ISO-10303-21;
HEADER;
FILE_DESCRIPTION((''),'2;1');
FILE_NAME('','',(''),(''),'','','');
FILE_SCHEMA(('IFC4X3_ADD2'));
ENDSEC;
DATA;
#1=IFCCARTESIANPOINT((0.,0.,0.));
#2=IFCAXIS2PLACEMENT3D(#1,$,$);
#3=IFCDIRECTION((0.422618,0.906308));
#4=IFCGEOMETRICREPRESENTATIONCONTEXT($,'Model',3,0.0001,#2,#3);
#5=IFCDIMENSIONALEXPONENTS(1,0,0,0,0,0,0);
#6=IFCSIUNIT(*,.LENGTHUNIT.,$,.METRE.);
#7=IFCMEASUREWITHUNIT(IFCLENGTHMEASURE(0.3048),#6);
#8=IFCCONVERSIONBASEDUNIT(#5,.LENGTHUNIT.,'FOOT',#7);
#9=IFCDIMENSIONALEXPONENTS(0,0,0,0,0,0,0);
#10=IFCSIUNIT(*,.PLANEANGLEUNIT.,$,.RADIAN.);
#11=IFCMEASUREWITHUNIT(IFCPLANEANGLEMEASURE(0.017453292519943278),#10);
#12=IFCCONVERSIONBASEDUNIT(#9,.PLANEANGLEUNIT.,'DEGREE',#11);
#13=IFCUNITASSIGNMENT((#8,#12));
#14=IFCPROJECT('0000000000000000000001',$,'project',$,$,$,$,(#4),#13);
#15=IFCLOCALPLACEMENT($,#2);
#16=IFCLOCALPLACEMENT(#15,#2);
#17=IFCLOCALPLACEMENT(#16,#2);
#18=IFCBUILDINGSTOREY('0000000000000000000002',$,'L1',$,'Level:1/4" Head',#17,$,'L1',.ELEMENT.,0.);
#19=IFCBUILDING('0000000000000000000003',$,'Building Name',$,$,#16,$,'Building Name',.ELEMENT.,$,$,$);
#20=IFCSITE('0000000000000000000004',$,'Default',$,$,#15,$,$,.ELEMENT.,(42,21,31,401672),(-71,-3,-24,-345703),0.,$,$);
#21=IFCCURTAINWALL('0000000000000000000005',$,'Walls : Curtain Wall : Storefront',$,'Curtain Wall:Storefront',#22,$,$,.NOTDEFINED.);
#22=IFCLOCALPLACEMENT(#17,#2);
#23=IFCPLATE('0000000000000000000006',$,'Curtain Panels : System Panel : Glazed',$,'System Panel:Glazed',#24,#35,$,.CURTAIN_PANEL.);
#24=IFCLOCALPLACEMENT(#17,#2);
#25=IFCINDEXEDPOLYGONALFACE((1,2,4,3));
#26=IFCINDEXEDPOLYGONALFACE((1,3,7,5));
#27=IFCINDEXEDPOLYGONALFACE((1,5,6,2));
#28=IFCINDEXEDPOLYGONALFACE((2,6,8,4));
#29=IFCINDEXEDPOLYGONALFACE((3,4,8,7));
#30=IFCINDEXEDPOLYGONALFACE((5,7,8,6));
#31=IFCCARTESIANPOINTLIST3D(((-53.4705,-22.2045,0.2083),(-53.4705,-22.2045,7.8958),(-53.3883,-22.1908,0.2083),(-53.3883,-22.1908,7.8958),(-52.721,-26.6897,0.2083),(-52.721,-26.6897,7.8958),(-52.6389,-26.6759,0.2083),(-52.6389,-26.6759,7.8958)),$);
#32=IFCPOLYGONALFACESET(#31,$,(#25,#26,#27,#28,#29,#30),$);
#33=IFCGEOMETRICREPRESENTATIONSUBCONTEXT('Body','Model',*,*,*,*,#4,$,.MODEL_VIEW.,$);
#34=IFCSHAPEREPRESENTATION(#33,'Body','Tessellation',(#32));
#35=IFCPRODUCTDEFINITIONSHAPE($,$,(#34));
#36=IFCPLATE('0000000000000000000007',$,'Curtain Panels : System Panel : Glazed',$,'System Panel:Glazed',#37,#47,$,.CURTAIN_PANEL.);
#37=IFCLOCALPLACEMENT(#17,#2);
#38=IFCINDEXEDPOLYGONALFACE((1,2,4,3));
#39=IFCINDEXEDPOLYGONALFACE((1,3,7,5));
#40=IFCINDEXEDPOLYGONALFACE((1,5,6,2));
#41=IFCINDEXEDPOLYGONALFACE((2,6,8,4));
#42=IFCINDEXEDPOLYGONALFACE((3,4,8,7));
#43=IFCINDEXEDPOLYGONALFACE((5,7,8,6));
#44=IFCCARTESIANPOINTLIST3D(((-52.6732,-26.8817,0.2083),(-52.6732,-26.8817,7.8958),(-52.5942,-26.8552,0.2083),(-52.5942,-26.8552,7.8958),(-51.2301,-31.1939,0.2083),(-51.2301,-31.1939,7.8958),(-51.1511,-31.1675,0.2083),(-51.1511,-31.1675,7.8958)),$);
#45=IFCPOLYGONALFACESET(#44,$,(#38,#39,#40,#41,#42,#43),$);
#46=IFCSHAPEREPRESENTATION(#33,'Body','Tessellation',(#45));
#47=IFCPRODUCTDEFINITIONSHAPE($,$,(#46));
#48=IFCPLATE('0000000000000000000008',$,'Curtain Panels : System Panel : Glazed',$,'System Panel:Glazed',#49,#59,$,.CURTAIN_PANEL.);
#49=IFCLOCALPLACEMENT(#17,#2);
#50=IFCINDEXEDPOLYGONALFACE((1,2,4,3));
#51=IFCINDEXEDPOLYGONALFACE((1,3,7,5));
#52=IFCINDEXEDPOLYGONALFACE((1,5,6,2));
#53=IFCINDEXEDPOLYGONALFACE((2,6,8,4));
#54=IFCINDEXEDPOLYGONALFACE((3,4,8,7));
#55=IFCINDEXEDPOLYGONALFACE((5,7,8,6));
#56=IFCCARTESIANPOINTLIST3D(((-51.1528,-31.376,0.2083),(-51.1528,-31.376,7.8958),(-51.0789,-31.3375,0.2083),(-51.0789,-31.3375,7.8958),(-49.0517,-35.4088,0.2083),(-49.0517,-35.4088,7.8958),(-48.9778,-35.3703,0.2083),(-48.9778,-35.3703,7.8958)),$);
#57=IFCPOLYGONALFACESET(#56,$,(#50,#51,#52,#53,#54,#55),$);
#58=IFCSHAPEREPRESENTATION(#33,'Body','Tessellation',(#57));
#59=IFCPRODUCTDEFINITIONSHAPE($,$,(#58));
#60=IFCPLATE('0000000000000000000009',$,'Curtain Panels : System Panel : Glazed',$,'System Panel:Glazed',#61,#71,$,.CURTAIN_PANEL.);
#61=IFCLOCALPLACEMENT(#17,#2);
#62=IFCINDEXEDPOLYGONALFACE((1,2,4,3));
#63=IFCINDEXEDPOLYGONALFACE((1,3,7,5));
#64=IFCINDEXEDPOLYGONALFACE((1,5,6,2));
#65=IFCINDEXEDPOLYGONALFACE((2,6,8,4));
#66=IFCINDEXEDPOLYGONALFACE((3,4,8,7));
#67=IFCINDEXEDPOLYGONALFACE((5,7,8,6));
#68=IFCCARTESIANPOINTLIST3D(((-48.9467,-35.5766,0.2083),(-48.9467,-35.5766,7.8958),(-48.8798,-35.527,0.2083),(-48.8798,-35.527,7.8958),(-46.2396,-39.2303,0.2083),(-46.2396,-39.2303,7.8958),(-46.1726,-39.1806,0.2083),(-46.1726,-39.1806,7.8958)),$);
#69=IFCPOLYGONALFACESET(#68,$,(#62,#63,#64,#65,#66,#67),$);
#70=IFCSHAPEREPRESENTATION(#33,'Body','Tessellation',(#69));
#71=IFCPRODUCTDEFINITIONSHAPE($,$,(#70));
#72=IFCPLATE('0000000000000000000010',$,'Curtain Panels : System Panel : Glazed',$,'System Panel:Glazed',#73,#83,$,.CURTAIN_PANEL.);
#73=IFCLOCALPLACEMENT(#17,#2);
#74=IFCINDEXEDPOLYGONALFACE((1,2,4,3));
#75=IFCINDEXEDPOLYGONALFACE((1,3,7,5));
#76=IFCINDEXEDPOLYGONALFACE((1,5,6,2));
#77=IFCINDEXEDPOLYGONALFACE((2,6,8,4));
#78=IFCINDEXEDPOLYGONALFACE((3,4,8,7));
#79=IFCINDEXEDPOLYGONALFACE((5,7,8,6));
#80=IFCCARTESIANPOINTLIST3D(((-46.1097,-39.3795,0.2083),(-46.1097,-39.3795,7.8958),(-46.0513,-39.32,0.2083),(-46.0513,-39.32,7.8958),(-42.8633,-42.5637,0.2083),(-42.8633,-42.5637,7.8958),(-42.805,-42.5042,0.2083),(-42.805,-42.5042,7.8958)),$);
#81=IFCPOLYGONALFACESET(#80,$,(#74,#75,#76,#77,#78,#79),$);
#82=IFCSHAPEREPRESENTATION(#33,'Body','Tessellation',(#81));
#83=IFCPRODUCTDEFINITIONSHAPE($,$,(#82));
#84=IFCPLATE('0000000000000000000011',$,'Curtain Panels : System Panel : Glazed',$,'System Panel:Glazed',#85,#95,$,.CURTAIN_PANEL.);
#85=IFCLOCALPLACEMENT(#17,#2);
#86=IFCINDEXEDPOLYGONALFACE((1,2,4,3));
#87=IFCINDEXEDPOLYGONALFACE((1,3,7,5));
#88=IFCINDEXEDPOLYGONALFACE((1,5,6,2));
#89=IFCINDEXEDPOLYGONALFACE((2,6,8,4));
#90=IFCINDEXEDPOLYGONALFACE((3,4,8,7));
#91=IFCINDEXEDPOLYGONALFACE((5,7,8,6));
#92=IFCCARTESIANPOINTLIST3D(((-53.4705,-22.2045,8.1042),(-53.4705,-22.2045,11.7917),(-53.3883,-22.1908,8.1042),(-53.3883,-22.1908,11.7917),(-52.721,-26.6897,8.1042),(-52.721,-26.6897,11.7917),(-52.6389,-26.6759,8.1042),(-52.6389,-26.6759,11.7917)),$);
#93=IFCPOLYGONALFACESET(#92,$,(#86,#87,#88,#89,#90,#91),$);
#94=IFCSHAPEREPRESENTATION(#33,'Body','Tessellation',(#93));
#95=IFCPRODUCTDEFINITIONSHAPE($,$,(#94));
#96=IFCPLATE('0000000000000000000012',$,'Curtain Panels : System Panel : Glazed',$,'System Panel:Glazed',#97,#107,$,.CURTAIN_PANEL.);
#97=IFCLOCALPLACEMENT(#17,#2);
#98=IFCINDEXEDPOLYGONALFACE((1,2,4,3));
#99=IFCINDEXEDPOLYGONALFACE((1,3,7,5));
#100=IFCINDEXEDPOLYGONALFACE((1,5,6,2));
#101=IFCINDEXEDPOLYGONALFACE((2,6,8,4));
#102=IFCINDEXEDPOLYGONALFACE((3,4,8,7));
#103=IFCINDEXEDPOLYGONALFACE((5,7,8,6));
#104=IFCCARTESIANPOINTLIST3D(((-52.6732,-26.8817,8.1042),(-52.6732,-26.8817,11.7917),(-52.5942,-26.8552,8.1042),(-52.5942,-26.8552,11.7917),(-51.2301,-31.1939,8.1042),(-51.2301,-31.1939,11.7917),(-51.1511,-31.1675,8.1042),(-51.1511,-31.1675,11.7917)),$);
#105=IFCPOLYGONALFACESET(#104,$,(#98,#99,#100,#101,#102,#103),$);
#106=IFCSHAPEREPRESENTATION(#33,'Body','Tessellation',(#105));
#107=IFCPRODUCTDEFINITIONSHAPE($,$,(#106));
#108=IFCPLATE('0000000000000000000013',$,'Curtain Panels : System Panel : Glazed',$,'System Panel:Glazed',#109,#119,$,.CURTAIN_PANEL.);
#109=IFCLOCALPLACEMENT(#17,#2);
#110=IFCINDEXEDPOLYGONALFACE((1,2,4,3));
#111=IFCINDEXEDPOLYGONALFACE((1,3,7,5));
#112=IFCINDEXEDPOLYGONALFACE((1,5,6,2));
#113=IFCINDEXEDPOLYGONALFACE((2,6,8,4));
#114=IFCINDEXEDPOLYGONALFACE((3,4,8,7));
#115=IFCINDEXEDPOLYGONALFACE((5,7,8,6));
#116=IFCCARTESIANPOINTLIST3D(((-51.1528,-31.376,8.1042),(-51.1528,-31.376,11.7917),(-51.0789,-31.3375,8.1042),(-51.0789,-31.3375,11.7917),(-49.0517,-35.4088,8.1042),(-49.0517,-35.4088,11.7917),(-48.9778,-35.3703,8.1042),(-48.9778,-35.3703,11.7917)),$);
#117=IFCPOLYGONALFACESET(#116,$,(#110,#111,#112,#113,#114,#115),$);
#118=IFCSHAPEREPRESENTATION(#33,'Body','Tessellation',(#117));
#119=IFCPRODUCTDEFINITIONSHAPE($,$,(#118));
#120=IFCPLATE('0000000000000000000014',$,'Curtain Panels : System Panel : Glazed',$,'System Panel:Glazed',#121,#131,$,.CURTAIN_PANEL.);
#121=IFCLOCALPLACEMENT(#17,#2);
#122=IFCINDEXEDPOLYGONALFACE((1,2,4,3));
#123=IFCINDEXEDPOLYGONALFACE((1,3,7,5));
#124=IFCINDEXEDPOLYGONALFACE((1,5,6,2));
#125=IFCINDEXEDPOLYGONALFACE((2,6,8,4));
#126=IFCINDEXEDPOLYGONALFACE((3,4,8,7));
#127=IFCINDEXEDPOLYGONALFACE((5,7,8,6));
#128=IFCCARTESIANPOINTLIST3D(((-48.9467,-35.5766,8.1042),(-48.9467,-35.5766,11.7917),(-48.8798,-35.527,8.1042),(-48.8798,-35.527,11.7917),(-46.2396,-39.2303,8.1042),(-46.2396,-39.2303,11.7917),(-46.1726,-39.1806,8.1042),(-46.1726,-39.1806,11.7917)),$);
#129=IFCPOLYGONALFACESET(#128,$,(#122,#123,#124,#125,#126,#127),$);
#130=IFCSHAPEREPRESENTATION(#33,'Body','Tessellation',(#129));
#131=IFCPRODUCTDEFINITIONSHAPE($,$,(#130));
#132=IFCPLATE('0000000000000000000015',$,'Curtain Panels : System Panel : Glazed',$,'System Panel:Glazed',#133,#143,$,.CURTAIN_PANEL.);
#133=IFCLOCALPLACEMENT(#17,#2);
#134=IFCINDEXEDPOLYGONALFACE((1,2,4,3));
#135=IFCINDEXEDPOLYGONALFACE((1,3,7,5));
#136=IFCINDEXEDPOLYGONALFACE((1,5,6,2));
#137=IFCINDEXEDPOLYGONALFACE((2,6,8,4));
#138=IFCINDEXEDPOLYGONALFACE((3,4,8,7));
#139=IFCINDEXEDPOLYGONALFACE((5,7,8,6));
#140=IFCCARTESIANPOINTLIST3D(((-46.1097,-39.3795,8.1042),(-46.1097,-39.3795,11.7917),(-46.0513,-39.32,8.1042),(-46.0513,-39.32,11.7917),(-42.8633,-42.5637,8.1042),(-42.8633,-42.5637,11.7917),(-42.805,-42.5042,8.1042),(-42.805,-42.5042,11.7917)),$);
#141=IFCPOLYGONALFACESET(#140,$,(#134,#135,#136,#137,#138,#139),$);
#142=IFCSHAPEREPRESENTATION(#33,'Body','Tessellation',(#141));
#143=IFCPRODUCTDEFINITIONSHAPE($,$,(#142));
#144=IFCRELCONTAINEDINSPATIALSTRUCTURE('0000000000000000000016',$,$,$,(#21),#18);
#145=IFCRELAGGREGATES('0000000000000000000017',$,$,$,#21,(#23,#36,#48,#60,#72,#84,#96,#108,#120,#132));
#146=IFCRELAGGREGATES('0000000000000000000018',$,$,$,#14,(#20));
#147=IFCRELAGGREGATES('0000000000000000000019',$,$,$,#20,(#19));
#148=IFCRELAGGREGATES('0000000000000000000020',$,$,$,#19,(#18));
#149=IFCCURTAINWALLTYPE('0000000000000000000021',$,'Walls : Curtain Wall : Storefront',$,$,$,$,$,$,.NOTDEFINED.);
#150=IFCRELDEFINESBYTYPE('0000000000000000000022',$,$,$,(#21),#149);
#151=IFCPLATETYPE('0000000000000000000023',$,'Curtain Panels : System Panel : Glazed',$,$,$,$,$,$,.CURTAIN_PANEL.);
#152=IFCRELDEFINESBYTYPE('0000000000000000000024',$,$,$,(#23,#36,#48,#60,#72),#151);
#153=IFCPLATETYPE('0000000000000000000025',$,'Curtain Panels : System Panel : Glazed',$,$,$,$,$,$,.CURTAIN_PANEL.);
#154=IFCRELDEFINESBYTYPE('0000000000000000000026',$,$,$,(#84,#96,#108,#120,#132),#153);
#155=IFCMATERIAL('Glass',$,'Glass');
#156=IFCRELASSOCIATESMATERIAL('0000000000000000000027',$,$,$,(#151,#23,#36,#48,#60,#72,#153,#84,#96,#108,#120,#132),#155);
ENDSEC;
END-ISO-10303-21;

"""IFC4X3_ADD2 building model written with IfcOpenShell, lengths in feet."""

from ifc_helpers import new_model, entity, si_unit, converted_unit, direction, frame, frame_2d, origin, place, context, subcontext, project, spatial, rectangle, extrude, source, transform, mapped, material, type_object, type_shapes, element, aggregate, save


model = new_model("IFC4X3_ADD2")

# Units and contexts
model_context = context("Model", 3, precision=0.0001, world=origin(), true_north=direction((0.422618, 0.906308)))
body_context = subcontext(model_context, "Body", "Model", "MODEL_VIEW")
ifc_project = project(units=[converted_unit("LENGTHUNIT", "FOOT", entity("IfcLengthMeasure", 0.3048), si_unit("LENGTHUNIT", "METRE"), dimensions=[1, 0, 0, 0, 0, 0, 0]), converted_unit("PLANEANGLEUNIT", "DEGREE", entity("IfcPlaneAngleMeasure", 0.017453292519943278), si_unit("PLANEANGLEUNIT", "RADIAN"), dimensions=[0, 0, 0, 0, 0, 0, 0])], contexts=[model_context])

# Site, building, storey
site_placement = place(None, origin())
site = spatial("IfcSite", under=ifc_project, at=site_placement, Name="Default", CompositionType="ELEMENT", RefLatitude=(42, 21, 31, 401672), RefLongitude=(-71, -3, -24, -345703), RefElevation=0.0)
building_placement = place(site_placement, origin())
building = spatial("IfcBuilding", under=site, at=building_placement, Name="Building Name", LongName="Building Name", CompositionType="ELEMENT")
storey_placement = place(building_placement, origin())
storey = spatial("IfcBuildingStorey", under=building, at=storey_placement, Name="L1", ObjectType="Level:1/4\" Head", LongName="L1", CompositionType="ELEMENT", Elevation=0.0)

# Curtain wall, plates
curtain_wall_type = type_object("IfcCurtainWallType", Name="Walls : Curtain Wall : Storefront", PredefinedType="NOTDEFINED")
curtain_wall_placement = place(storey_placement, origin())
curtain_wall = element("IfcCurtainWall", 1, at=curtain_wall_placement, inside=storey, type_object=curtain_wall_type, Name="Walls : Curtain Wall : Storefront", ObjectType="Curtain Wall:Storefront", PredefinedType="NOTDEFINED")
ifc_material_1 = material(Name="Glass", Category="Glass")
plate_type_1 = type_object("IfcPlateType", Name="Curtain Panels : System Panel : Glazed", PredefinedType="CURTAIN_PANEL", material=ifc_material_1)
shared_shape_1 = source(origin(), body_context, "Body", "SweptSolid", [
    extrude(rectangle(XDim=0.0833, YDim=4.5473, at=frame_2d((0.0, 0.0), x_axis=(1.0, 0.0))), frame((2.2737, 0.0417, 0.0), z_axis=(0.0, 0.0, 1.0), x_axis=(0.0, 1.0, 0.0)), (0.0, 0.0, 1.0), 7.6875),
])
type_shapes(plate_type_1, [shared_shape_1])
plate_1_placement = place(curtain_wall_placement, frame((-53.4705, -22.2045, 0.2083), z_axis=(0.0, 0.0, 1.0), x_axis=(0.164805, -0.986326, 0.0)))
plate_1 = element("IfcPlate", 2, at=plate_1_placement, type_object=plate_type_1, material=ifc_material_1, Name="Curtain Panels : System Panel : Glazed", ObjectType="System Panel:Glazed", PredefinedType="CURTAIN_PANEL", context=body_context, shape_type="MappedRepresentation", body=[
    mapped(shared_shape_1, transform((0.0, 0.0, 0.0), scale=1.0)),
])
plate_2_placement = place(curtain_wall_placement, frame((-52.6732, -26.8817, 0.2083), z_axis=(0.0, 0.0, 1.0), x_axis=(0.31735, -0.948308, 0.0)))
plate_2 = element("IfcPlate", 3, at=plate_2_placement, type_object=plate_type_1, material=ifc_material_1, Name="Curtain Panels : System Panel : Glazed", ObjectType="System Panel:Glazed", PredefinedType="CURTAIN_PANEL", context=body_context, shape_type="MappedRepresentation", body=[
    mapped(shared_shape_1, transform((0.0, 0.0, 0.0), scale=1.0)),
])
plate_3_placement = place(curtain_wall_placement, frame((-51.1528, -31.376, 0.2083), z_axis=(0.0, 0.0, 1.0), x_axis=(0.462051, -0.886853, 0.0)))
plate_3 = element("IfcPlate", 4, at=plate_3_placement, type_object=plate_type_1, material=ifc_material_1, Name="Curtain Panels : System Panel : Glazed", ObjectType="System Panel:Glazed", PredefinedType="CURTAIN_PANEL", context=body_context, shape_type="MappedRepresentation", body=[
    mapped(shared_shape_1, transform((0.0, 0.0, 0.0), scale=1.0)),
])
plate_4_placement = place(curtain_wall_placement, frame((-48.9467, -35.5766, 0.2083), z_axis=(0.0, 0.0, 1.0), x_axis=(0.595333, -0.803479, 0.0)))
plate_4 = element("IfcPlate", 5, at=plate_4_placement, type_object=plate_type_1, material=ifc_material_1, Name="Curtain Panels : System Panel : Glazed", ObjectType="System Panel:Glazed", PredefinedType="CURTAIN_PANEL", context=body_context, shape_type="MappedRepresentation", body=[
    mapped(shared_shape_1, transform((0.0, 0.0, 0.0), scale=1.0)),
])
plate_5_placement = place(curtain_wall_placement, frame((-46.1097, -39.3795, 0.2083), z_axis=(0.0, 0.0, 1.0), x_axis=(0.713901, -0.700247, 0.0)))
plate_5 = element("IfcPlate", 6, at=plate_5_placement, type_object=plate_type_1, material=ifc_material_1, Name="Curtain Panels : System Panel : Glazed", ObjectType="System Panel:Glazed", PredefinedType="CURTAIN_PANEL", context=body_context, shape_type="MappedRepresentation", body=[
    mapped(shared_shape_1, transform((0.0, 0.0, 0.0), scale=1.0)),
])
plate_type_2 = type_object("IfcPlateType", Name="Curtain Panels : System Panel : Glazed", PredefinedType="CURTAIN_PANEL", material=ifc_material_1)
shared_shape_2 = source(origin(), body_context, "Body", "SweptSolid", [
    extrude(rectangle(XDim=0.0833, YDim=4.5473, at=frame_2d((0.0, 0.0), x_axis=(1.0, 0.0))), frame((2.2737, 0.0417, 0.0), z_axis=(0.0, 0.0, 1.0), x_axis=(0.0, 1.0, 0.0)), (0.0, 0.0, 1.0), 3.6875),
])
type_shapes(plate_type_2, [shared_shape_2])
plate_6_placement = place(curtain_wall_placement, frame((-53.4705, -22.2045, 8.1042), z_axis=(0.0, 0.0, 1.0), x_axis=(0.164805, -0.986326, 0.0)))
plate_6 = element("IfcPlate", 7, at=plate_6_placement, type_object=plate_type_2, material=ifc_material_1, Name="Curtain Panels : System Panel : Glazed", ObjectType="System Panel:Glazed", PredefinedType="CURTAIN_PANEL", context=body_context, shape_type="MappedRepresentation", body=[
    mapped(shared_shape_2, transform((0.0, 0.0, 0.0), scale=1.0)),
])
plate_7_placement = place(curtain_wall_placement, frame((-52.6732, -26.8817, 8.1042), z_axis=(0.0, 0.0, 1.0), x_axis=(0.31735, -0.948308, 0.0)))
plate_7 = element("IfcPlate", 8, at=plate_7_placement, type_object=plate_type_2, material=ifc_material_1, Name="Curtain Panels : System Panel : Glazed", ObjectType="System Panel:Glazed", PredefinedType="CURTAIN_PANEL", context=body_context, shape_type="MappedRepresentation", body=[
    mapped(shared_shape_2, transform((0.0, 0.0, 0.0), scale=1.0)),
])
plate_8_placement = place(curtain_wall_placement, frame((-51.1528, -31.376, 8.1042), z_axis=(0.0, 0.0, 1.0), x_axis=(0.462051, -0.886853, 0.0)))
plate_8 = element("IfcPlate", 9, at=plate_8_placement, type_object=plate_type_2, material=ifc_material_1, Name="Curtain Panels : System Panel : Glazed", ObjectType="System Panel:Glazed", PredefinedType="CURTAIN_PANEL", context=body_context, shape_type="MappedRepresentation", body=[
    mapped(shared_shape_2, transform((0.0, 0.0, 0.0), scale=1.0)),
])
plate_9_placement = place(curtain_wall_placement, frame((-48.9467, -35.5766, 8.1042), z_axis=(0.0, 0.0, 1.0), x_axis=(0.595333, -0.803479, 0.0)))
plate_9 = element("IfcPlate", 10, at=plate_9_placement, type_object=plate_type_2, material=ifc_material_1, Name="Curtain Panels : System Panel : Glazed", ObjectType="System Panel:Glazed", PredefinedType="CURTAIN_PANEL", context=body_context, shape_type="MappedRepresentation", body=[
    mapped(shared_shape_2, transform((0.0, 0.0, 0.0), scale=1.0)),
])
plate_10_placement = place(curtain_wall_placement, frame((-46.1097, -39.3795, 8.1042), z_axis=(0.0, 0.0, 1.0), x_axis=(0.713901, -0.700247, 0.0)))
plate_10 = element("IfcPlate", 11, at=plate_10_placement, type_object=plate_type_2, material=ifc_material_1, Name="Curtain Panels : System Panel : Glazed", ObjectType="System Panel:Glazed", PredefinedType="CURTAIN_PANEL", context=body_context, shape_type="MappedRepresentation", body=[
    mapped(shared_shape_2, transform((0.0, 0.0, 0.0), scale=1.0)),
])
aggregate(curtain_wall, [plate_1, plate_2, plate_3, plate_4, plate_5, plate_6, plate_7, plate_8, plate_9, plate_10])

save(model, "model.ifc")
